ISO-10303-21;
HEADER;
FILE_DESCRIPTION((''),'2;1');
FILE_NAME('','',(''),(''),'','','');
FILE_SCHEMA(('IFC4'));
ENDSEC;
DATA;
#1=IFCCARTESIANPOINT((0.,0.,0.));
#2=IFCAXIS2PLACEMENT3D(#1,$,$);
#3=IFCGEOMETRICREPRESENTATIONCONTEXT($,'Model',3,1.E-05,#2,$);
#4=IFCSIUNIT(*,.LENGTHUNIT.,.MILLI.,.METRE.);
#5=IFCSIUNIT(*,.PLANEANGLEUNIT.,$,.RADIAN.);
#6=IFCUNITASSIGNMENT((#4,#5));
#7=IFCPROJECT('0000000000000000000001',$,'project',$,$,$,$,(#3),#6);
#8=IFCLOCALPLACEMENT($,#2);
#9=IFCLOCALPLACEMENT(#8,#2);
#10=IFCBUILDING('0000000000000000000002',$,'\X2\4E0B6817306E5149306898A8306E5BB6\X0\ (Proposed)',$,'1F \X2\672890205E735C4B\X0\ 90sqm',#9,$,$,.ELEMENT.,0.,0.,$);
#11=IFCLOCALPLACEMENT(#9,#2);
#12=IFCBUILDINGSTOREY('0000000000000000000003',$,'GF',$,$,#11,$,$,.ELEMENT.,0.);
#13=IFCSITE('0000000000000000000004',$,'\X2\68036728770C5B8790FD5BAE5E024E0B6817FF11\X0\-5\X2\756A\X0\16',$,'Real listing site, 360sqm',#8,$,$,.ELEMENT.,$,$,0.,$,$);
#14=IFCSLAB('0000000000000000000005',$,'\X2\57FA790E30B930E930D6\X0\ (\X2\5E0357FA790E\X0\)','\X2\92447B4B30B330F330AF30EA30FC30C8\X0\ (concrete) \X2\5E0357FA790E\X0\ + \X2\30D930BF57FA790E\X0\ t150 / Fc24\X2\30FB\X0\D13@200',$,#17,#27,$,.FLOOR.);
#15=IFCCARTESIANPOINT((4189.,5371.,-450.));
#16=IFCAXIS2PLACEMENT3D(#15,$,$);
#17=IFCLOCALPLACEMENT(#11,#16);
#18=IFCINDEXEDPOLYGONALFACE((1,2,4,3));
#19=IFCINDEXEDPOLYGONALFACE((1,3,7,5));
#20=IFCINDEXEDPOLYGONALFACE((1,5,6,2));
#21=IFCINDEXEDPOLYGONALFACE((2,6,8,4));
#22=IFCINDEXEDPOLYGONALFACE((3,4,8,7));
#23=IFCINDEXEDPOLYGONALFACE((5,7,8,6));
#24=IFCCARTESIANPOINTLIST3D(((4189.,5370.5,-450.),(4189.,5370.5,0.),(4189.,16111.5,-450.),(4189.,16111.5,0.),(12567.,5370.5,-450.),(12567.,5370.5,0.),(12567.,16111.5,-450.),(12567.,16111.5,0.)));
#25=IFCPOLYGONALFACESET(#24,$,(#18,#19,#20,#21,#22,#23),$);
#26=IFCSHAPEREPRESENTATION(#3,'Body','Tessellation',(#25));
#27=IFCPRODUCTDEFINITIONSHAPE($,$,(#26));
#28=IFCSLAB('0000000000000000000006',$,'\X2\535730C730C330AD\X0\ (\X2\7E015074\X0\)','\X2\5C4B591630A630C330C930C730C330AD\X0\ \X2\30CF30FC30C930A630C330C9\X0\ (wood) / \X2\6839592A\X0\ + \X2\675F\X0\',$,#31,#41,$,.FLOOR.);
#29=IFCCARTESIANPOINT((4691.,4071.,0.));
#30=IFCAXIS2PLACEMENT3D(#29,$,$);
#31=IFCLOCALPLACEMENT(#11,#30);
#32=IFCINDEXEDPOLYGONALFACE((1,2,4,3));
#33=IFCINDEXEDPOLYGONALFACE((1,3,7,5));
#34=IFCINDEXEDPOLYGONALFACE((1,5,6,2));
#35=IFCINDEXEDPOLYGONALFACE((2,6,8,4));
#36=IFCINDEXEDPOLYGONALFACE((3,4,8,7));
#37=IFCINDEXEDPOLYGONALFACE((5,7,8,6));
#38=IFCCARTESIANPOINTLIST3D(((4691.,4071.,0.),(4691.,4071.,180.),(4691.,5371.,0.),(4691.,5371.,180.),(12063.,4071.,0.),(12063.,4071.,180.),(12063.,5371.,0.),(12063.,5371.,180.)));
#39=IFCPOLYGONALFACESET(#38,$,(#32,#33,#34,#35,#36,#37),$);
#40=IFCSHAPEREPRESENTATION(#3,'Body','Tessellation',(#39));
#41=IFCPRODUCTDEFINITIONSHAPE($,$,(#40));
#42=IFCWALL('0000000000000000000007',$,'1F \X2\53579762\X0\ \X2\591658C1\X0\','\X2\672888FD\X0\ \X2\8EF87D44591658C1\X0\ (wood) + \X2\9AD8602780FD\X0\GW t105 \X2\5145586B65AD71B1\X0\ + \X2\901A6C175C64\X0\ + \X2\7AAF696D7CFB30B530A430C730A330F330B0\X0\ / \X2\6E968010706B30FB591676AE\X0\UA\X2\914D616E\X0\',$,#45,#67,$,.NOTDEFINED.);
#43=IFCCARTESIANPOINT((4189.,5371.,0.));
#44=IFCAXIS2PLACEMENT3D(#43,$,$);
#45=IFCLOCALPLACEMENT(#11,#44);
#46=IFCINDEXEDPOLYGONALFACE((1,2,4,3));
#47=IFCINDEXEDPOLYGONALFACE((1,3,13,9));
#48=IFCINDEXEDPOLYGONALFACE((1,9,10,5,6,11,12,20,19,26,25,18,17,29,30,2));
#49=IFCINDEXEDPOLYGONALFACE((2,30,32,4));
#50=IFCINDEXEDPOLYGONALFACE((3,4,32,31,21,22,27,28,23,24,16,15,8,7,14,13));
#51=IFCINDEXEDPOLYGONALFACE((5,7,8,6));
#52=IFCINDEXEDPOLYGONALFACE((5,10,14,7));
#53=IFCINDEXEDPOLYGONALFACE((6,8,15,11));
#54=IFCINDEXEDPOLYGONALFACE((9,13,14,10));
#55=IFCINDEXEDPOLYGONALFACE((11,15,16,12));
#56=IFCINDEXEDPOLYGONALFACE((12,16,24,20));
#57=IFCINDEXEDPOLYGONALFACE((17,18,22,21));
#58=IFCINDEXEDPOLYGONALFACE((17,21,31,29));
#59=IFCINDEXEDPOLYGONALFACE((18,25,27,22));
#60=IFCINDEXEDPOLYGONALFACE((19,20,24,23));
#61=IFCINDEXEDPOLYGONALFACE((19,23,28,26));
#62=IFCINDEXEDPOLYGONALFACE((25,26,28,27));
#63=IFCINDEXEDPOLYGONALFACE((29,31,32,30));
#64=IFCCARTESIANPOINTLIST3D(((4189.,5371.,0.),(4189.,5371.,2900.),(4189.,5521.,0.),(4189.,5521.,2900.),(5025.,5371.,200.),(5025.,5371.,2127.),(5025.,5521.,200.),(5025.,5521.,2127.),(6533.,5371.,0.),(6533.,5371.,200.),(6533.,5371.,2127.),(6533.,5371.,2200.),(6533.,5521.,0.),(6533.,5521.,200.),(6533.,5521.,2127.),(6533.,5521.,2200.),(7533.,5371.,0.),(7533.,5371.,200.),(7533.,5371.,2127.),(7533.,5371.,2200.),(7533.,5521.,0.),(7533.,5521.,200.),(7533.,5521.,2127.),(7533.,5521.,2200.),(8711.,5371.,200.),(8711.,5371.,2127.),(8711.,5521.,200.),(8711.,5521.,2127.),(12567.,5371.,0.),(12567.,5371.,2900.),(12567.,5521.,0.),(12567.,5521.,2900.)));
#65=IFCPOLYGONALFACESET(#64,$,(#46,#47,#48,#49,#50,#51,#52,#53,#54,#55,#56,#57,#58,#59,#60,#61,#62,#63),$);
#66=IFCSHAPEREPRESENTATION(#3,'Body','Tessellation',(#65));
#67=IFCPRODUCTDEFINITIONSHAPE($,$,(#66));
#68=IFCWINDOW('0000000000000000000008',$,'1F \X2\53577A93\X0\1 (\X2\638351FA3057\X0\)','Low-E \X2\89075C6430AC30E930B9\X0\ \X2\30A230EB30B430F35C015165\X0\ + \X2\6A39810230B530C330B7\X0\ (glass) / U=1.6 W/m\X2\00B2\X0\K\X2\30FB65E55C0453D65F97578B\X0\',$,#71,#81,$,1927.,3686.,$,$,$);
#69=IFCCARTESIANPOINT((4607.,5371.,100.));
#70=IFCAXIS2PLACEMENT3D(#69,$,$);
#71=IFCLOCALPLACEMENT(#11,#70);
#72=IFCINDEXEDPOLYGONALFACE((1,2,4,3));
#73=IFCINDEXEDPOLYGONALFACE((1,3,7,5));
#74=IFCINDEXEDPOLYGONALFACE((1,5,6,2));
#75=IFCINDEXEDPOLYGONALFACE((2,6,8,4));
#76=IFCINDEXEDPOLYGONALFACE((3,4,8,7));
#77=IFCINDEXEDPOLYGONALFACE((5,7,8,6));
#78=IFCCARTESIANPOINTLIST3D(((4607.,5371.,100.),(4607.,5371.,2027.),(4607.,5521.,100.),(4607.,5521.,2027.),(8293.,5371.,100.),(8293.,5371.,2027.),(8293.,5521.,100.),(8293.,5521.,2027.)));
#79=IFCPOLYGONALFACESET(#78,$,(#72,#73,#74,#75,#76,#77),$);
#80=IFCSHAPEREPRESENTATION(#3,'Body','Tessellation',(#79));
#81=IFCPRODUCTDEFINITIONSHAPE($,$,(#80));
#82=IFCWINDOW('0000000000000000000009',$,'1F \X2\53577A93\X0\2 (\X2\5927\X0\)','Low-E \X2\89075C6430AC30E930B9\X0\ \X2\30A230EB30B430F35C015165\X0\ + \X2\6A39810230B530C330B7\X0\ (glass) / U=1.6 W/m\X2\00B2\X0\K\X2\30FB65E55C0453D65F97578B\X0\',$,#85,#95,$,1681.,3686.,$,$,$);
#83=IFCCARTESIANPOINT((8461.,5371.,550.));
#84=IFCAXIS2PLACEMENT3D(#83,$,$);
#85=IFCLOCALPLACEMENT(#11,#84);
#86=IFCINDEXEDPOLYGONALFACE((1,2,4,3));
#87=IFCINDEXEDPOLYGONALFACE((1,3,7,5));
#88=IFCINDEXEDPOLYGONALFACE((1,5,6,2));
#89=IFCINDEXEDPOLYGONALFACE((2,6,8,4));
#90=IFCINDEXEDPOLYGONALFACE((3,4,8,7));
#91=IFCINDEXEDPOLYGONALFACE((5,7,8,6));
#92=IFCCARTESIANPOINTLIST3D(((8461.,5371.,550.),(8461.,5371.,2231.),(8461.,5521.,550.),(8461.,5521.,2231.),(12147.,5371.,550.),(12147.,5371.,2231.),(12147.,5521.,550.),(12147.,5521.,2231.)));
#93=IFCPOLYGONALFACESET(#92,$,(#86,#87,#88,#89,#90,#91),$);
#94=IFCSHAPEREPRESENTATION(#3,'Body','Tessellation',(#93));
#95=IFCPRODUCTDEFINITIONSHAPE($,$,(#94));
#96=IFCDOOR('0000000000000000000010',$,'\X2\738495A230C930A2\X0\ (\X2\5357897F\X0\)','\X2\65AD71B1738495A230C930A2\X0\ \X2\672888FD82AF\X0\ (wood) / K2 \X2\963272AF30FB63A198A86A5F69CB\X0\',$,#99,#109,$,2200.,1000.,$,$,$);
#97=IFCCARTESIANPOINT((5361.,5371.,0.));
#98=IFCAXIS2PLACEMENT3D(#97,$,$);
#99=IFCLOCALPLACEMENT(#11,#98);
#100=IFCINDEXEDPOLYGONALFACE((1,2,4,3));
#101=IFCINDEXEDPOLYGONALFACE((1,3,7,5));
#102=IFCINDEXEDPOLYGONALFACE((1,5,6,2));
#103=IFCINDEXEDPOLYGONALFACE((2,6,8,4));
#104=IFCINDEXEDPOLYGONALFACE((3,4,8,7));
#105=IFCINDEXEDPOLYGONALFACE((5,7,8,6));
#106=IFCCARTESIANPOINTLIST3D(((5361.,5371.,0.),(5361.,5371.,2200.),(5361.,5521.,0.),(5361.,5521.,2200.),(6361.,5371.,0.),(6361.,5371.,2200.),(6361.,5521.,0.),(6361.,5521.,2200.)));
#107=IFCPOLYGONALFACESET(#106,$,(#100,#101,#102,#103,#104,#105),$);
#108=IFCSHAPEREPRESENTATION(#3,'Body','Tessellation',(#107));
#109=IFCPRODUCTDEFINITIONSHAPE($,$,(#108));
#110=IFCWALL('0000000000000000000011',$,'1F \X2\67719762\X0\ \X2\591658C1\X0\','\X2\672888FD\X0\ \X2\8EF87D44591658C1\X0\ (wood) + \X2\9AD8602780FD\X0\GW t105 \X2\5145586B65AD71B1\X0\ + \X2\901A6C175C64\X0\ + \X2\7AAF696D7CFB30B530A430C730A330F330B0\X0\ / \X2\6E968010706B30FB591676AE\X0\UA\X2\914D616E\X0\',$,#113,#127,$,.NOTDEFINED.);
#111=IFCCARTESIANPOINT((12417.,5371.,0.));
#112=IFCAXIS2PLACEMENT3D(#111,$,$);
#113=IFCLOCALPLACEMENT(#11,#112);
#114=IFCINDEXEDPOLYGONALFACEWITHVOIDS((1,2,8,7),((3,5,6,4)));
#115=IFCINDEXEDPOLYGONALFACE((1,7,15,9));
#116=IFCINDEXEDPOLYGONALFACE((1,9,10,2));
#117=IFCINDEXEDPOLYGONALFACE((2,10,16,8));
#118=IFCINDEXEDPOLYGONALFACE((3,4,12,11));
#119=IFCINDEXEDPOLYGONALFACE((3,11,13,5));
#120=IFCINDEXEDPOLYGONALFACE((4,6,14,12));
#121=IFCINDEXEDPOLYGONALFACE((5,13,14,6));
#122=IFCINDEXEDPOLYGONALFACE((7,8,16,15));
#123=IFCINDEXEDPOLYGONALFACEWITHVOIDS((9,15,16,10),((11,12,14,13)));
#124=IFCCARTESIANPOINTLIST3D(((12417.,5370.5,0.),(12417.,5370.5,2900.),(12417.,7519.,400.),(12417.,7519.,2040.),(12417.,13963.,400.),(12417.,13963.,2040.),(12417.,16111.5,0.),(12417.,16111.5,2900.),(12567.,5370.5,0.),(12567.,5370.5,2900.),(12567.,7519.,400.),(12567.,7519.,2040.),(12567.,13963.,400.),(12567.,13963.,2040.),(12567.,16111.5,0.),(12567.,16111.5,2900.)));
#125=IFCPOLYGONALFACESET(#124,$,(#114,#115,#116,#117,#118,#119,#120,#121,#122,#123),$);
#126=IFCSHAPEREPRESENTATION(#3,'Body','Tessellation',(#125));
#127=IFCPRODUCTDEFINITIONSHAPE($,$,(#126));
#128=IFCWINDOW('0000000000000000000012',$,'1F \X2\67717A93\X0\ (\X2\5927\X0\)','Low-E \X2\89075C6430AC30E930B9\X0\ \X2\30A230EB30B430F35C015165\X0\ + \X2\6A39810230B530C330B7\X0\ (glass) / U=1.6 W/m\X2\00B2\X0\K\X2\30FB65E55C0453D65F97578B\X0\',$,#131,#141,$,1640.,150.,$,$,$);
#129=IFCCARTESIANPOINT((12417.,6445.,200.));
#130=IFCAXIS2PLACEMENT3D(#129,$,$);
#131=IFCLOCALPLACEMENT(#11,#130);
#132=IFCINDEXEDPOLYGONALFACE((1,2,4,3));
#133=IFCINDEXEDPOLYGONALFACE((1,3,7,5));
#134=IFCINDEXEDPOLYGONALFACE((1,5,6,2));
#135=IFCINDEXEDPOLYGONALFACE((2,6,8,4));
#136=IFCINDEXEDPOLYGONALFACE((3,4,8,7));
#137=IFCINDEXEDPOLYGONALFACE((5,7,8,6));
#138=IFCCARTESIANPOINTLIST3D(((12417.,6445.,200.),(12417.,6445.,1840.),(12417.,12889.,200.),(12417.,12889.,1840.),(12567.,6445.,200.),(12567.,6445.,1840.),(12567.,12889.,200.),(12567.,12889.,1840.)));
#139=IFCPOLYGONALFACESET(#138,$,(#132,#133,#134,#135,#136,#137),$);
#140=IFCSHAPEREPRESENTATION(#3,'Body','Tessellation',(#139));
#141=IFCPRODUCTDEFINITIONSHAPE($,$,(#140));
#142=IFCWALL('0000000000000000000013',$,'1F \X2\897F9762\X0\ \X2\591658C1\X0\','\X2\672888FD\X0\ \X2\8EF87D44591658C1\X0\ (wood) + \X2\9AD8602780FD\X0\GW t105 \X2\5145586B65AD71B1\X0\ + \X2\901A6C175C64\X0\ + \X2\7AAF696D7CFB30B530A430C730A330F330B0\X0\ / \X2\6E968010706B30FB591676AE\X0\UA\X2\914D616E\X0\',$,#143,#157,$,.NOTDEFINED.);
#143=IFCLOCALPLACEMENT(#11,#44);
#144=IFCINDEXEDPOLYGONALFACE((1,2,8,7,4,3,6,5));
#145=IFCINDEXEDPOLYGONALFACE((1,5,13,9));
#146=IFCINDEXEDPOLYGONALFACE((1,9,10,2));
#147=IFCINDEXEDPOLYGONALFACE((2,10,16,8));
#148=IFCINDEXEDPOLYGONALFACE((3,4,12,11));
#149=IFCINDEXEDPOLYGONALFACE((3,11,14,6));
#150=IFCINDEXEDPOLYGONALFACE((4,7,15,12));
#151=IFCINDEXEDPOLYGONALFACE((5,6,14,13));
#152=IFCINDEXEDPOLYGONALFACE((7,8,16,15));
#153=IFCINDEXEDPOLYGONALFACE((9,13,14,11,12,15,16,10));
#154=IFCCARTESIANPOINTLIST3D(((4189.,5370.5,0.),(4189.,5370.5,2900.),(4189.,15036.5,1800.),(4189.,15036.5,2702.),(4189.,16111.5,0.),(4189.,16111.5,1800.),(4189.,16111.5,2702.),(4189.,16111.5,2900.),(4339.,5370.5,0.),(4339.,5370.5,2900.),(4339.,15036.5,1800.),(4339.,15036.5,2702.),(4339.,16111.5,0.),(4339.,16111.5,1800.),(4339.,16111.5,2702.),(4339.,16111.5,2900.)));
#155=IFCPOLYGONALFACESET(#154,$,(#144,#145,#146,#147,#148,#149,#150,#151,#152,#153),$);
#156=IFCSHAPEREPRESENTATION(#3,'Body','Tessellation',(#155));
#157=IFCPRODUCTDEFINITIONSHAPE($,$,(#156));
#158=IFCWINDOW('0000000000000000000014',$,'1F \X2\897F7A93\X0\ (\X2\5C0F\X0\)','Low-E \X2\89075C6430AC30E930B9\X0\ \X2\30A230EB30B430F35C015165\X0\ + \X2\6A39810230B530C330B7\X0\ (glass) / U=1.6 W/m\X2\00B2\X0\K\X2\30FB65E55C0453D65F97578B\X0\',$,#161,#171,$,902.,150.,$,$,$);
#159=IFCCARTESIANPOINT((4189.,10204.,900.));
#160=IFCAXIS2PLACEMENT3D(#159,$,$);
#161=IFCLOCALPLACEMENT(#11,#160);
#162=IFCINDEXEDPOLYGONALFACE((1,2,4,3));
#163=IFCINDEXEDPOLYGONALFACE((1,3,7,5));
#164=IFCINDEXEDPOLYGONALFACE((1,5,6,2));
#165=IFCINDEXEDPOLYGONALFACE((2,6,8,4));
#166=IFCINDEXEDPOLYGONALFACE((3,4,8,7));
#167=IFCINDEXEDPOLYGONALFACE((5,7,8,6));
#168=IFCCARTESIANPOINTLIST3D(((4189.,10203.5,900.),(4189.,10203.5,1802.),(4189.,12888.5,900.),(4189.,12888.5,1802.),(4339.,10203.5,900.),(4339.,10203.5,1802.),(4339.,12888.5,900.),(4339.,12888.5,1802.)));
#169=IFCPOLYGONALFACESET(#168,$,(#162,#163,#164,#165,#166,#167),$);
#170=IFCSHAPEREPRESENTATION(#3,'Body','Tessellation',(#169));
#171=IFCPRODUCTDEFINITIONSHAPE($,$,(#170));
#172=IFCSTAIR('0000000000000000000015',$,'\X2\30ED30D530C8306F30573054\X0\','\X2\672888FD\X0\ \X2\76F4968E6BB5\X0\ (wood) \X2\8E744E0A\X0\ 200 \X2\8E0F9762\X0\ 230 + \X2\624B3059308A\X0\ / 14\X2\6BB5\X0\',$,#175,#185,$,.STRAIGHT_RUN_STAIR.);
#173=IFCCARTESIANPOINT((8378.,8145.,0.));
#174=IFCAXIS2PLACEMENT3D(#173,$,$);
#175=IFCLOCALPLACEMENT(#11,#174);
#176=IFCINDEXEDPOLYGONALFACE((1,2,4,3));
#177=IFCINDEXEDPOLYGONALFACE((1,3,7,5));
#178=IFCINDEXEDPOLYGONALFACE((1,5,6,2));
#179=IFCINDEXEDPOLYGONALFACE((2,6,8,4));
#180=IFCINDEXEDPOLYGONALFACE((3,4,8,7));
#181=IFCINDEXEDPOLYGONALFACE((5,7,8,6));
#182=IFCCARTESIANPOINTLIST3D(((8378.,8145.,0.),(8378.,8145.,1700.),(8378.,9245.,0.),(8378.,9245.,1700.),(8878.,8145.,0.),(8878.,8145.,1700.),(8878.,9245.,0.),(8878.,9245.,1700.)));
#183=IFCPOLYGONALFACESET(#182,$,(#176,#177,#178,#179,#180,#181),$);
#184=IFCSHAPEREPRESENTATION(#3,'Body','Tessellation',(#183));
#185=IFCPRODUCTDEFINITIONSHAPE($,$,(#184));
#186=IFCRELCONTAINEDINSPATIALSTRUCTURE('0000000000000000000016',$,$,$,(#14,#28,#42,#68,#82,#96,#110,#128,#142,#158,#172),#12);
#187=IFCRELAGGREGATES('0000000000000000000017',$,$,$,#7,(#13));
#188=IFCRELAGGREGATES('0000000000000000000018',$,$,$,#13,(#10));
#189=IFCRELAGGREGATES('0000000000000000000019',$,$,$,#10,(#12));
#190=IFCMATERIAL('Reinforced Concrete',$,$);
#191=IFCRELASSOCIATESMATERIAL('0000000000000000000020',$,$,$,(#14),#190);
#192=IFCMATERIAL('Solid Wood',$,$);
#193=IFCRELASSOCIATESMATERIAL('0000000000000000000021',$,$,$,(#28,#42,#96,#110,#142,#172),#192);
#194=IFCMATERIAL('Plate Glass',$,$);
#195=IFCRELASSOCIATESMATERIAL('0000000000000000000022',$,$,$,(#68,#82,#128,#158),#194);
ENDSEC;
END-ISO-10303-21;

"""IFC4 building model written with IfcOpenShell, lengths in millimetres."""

from ifc_helpers import new_model, si_unit, frame, frame_2d, origin, place, context, project, spatial, rectangle, extrude, material, element, fill, save


model = new_model("IFC4")

# Units and contexts
model_context = context("Model", 3, precision=1e-05, world=origin())
ifc_project = project(units=[si_unit("LENGTHUNIT", "METRE", prefix="MILLI"), si_unit("PLANEANGLEUNIT", "RADIAN")], contexts=[model_context])

# Site, building, storey
site_placement = place(None, origin())
site = spatial("IfcSite", under=ifc_project, at=site_placement, Name="栃木県宇都宮市下栗１-5番16", ObjectType="Real listing site, 360sqm", CompositionType="ELEMENT", RefElevation=0.0)
building_placement = place(site_placement, origin())
building = spatial("IfcBuilding", under=site, at=building_placement, Name="下栗の光と風の家 (Proposed)", ObjectType="1F 木造平屋 90sqm", CompositionType="ELEMENT", ElevationOfRefHeight=0.0, ElevationOfTerrain=0.0)
storey_placement = place(building_placement, origin())
storey = spatial("IfcBuildingStorey", under=building, at=storey_placement, Name="GF", CompositionType="ELEMENT", Elevation=0.0)

# Slabs
ifc_material_1 = material(Name="Reinforced Concrete")
slab_1_placement = place(storey_placement, frame((4189.0, 5371.0, -450.0)))
element("IfcSlab", 1, at=slab_1_placement, inside=storey, material=ifc_material_1, Name="基礎スラブ (布基礎)", Description="鉄筋コンクリート (concrete) 布基礎 + ベタ基礎 t150 / Fc24・D13@200", PredefinedType="FLOOR", context=model_context, shape_type="SweptSolid", body=[
    extrude(rectangle(XDim=8378.0, YDim=10741.0, at=frame_2d((4189.0, 5370.0))), frame((4189.0, 5371.0, -450.0)), (0.0, 0.0, 1.0), 450.0),
])
ifc_material_2 = material(Name="Solid Wood")
slab_2_placement = place(storey_placement, frame((4691.0, 4071.0, 0.0)))
element("IfcSlab", 2, at=slab_2_placement, inside=storey, material=ifc_material_2, Name="南デッキ (縁側)", Description="屋外ウッドデッキ ハードウッド (wood) / 根太 + 束", PredefinedType="FLOOR", context=model_context, shape_type="SweptSolid", body=[
    extrude(rectangle(XDim=7372.0, YDim=1300.0, at=frame_2d((3686.0, 650.0))), frame((4691.0, 4071.0, 0.0)), (0.0, 0.0, 1.0), 180.0),
])

# Wall, openings, windows, door
wall_1_placement = place(storey_placement, frame((4189.0, 5371.0, 0.0)))
wall_1 = element("IfcWall", 3, at=wall_1_placement, inside=storey, material=ifc_material_2, Name="1F 南面 外壁", Description="木製 軸組外壁 (wood) + 高性能GW t105 充填断熱 + 通気層 + 窯業系サイディング / 準耐火・外皮UA配慮", PredefinedType="NOTDEFINED", context=model_context, shape_type="SweptSolid", body=[
    extrude(rectangle(XDim=8378.0, YDim=150.0, at=frame_2d((4189.0, 75.0))), frame((4189.0, 5371.0, 0.0)), (0.0, 0.0, 1.0), 2900.0),
])
opening_1_placement = place(storey_placement, frame((4607.0, 5371.0, 100.0)))
opening_1 = element("IfcOpeningElement", 4, at=opening_1_placement, cuts=wall_1, PredefinedType="NOTDEFINED", context=model_context, shape_type="SweptSolid", body=[
    extrude(rectangle(XDim=3686.0, YDim=150.0, at=frame_2d((1843.0, 75.0))), frame((4607.0, 5371.0, 100.0)), (0.0, 0.0, 1.0), 1927.0),
])
opening_2_placement = place(storey_placement, frame((8461.0, 5371.0, 550.0)))
opening_2 = element("IfcOpeningElement", 5, at=opening_2_placement, cuts=wall_1, PredefinedType="NOTDEFINED", context=model_context, shape_type="SweptSolid", body=[
    extrude(rectangle(XDim=3686.0, YDim=150.0, at=frame_2d((1843.0, 75.0))), frame((8461.0, 5371.0, 550.0)), (0.0, 0.0, 1.0), 1681.0),
])
opening_3_placement = place(storey_placement, frame((5361.0, 5371.0, 0.0)))
opening_3 = element("IfcOpeningElement", 6, at=opening_3_placement, cuts=wall_1, PredefinedType="NOTDEFINED", context=model_context, shape_type="SweptSolid", body=[
    extrude(rectangle(XDim=1000.0, YDim=150.0, at=frame_2d((500.0, 75.0))), frame((5361.0, 5371.0, 0.0)), (0.0, 0.0, 1.0), 2200.0),
])
ifc_material_3 = material(Name="Plate Glass")
window_1_placement = place(storey_placement, frame((4607.0, 5371.0, 100.0)))
window_1 = element("IfcWindow", 7, at=window_1_placement, inside=storey, material=ifc_material_3, Name="1F 南窓1 (掃出し)", Description="Low-E 複層ガラス アルゴン封入 + 樹脂サッシ (glass) / U=1.6 W/m²K・日射取得型", OverallHeight=1927.0, OverallWidth=3686.0, context=model_context, shape_type="SweptSolid", body=[
    extrude(rectangle(XDim=3686.0, YDim=150.0, at=frame_2d((1843.0, 75.0))), frame((4607.0, 5371.0, 100.0)), (0.0, 0.0, 1.0), 1927.0),
])
fill(opening_1, window_1)
window_2_placement = place(storey_placement, frame((8461.0, 5371.0, 550.0)))
window_2 = element("IfcWindow", 8, at=window_2_placement, inside=storey, material=ifc_material_3, Name="1F 南窓2 (大)", Description="Low-E 複層ガラス アルゴン封入 + 樹脂サッシ (glass) / U=1.6 W/m²K・日射取得型", OverallHeight=1681.0, OverallWidth=3686.0, context=model_context, shape_type="SweptSolid", body=[
    extrude(rectangle(XDim=3686.0, YDim=150.0, at=frame_2d((1843.0, 75.0))), frame((8461.0, 5371.0, 550.0)), (0.0, 0.0, 1.0), 1681.0),
])
fill(opening_2, window_2)
door_placement = place(storey_placement, frame((5361.0, 5371.0, 0.0)))
door = element("IfcDoor", 9, at=door_placement, inside=storey, material=ifc_material_2, Name="玄関ドア (南西)", Description="断熱玄関ドア 木製芯 (wood) / K2 防犯・採風機構", OverallHeight=2200.0, OverallWidth=1000.0, context=model_context, shape_type="SweptSolid", body=[
    extrude(rectangle(XDim=1000.0, YDim=150.0, at=frame_2d((500.0, 75.0))), frame((5361.0, 5371.0, 0.0)), (0.0, 0.0, 1.0), 2200.0),
])
fill(opening_3, door)

# Walls, openings, windows
wall_2_placement = place(storey_placement, frame((12417.0, 5371.0, 0.0)))
wall_2 = element("IfcWall", 10, at=wall_2_placement, inside=storey, material=ifc_material_2, Name="1F 東面 外壁", Description="木製 軸組外壁 (wood) + 高性能GW t105 充填断熱 + 通気層 + 窯業系サイディング / 準耐火・外皮UA配慮", PredefinedType="NOTDEFINED", context=model_context, shape_type="SweptSolid", body=[
    extrude(rectangle(XDim=150.0, YDim=10741.0, at=frame_2d((75.0, 5370.0))), frame((12417.0, 5371.0, 0.0)), (0.0, 0.0, 1.0), 2900.0),
])
opening_4_placement = place(storey_placement, frame((12417.0, 6445.0, 200.0)))
opening_4 = element("IfcOpeningElement", 11, at=opening_4_placement, cuts=wall_2, PredefinedType="NOTDEFINED", context=model_context, shape_type="SweptSolid", body=[
    extrude(rectangle(XDim=150.0, YDim=6444.0, at=frame_2d((75.0, 3222.0))), frame((12417.0, 6445.0, 200.0)), (0.0, 0.0, 1.0), 1640.0),
])
window_3_placement = place(storey_placement, frame((12417.0, 6445.0, 200.0)))
window_3 = element("IfcWindow", 12, at=window_3_placement, inside=storey, material=ifc_material_3, Name="1F 東窓 (大)", Description="Low-E 複層ガラス アルゴン封入 + 樹脂サッシ (glass) / U=1.6 W/m²K・日射取得型", OverallHeight=1640.0, OverallWidth=150.0, context=model_context, shape_type="SweptSolid", body=[
    extrude(rectangle(XDim=150.0, YDim=6444.0, at=frame_2d((75.0, 3222.0))), frame((12417.0, 6445.0, 200.0)), (0.0, 0.0, 1.0), 1640.0),
])
fill(opening_4, window_3)
wall_3_placement = place(storey_placement, frame((4189.0, 5371.0, 0.0)))
wall_3 = element("IfcWall", 13, at=wall_3_placement, inside=storey, material=ifc_material_2, Name="1F 西面 外壁", Description="木製 軸組外壁 (wood) + 高性能GW t105 充填断熱 + 通気層 + 窯業系サイディング / 準耐火・外皮UA配慮", PredefinedType="NOTDEFINED", context=model_context, shape_type="SweptSolid", body=[
    extrude(rectangle(XDim=150.0, YDim=10741.0, at=frame_2d((75.0, 5370.0))), frame((4189.0, 5371.0, 0.0)), (0.0, 0.0, 1.0), 2900.0),
])
opening_5_placement = place(storey_placement, frame((4189.0, 10204.0, 900.0)))
opening_5 = element("IfcOpeningElement", 14, at=opening_5_placement, cuts=wall_3, PredefinedType="NOTDEFINED", context=model_context, shape_type="SweptSolid", body=[
    extrude(rectangle(XDim=150.0, YDim=2685.0, at=frame_2d((75.0, 1342.0))), frame((4189.0, 10204.0, 900.0)), (0.0, 0.0, 1.0), 902.0),
])
window_4_placement = place(storey_placement, frame((4189.0, 10204.0, 900.0)))
window_4 = element("IfcWindow", 15, at=window_4_placement, inside=storey, material=ifc_material_3, Name="1F 西窓 (小)", Description="Low-E 複層ガラス アルゴン封入 + 樹脂サッシ (glass) / U=1.6 W/m²K・日射取得型", OverallHeight=902.0, OverallWidth=150.0, context=model_context, shape_type="SweptSolid", body=[
    extrude(rectangle(XDim=150.0, YDim=2685.0, at=frame_2d((75.0, 1342.0))), frame((4189.0, 10204.0, 900.0)), (0.0, 0.0, 1.0), 902.0),
])
fill(opening_5, window_4)

# Stair
stair_placement = place(storey_placement, frame((8378.0, 8145.0, 0.0)))
element("IfcStair", 16, at=stair_placement, inside=storey, material=ifc_material_2, Name="ロフトはしご", Description="木製 直階段 (wood) 蹴上 200 踏面 230 + 手すり / 14段", PredefinedType="STRAIGHT_RUN_STAIR", context=model_context, shape_type="SweptSolid", body=[
    extrude(rectangle(XDim=500.0, YDim=1100.0, at=frame_2d((250.0, 550.0))), frame((8378.0, 8145.0, 0.0)), (0.0, 0.0, 1.0), 1700.0),
])

save(model, "model.ifc")
